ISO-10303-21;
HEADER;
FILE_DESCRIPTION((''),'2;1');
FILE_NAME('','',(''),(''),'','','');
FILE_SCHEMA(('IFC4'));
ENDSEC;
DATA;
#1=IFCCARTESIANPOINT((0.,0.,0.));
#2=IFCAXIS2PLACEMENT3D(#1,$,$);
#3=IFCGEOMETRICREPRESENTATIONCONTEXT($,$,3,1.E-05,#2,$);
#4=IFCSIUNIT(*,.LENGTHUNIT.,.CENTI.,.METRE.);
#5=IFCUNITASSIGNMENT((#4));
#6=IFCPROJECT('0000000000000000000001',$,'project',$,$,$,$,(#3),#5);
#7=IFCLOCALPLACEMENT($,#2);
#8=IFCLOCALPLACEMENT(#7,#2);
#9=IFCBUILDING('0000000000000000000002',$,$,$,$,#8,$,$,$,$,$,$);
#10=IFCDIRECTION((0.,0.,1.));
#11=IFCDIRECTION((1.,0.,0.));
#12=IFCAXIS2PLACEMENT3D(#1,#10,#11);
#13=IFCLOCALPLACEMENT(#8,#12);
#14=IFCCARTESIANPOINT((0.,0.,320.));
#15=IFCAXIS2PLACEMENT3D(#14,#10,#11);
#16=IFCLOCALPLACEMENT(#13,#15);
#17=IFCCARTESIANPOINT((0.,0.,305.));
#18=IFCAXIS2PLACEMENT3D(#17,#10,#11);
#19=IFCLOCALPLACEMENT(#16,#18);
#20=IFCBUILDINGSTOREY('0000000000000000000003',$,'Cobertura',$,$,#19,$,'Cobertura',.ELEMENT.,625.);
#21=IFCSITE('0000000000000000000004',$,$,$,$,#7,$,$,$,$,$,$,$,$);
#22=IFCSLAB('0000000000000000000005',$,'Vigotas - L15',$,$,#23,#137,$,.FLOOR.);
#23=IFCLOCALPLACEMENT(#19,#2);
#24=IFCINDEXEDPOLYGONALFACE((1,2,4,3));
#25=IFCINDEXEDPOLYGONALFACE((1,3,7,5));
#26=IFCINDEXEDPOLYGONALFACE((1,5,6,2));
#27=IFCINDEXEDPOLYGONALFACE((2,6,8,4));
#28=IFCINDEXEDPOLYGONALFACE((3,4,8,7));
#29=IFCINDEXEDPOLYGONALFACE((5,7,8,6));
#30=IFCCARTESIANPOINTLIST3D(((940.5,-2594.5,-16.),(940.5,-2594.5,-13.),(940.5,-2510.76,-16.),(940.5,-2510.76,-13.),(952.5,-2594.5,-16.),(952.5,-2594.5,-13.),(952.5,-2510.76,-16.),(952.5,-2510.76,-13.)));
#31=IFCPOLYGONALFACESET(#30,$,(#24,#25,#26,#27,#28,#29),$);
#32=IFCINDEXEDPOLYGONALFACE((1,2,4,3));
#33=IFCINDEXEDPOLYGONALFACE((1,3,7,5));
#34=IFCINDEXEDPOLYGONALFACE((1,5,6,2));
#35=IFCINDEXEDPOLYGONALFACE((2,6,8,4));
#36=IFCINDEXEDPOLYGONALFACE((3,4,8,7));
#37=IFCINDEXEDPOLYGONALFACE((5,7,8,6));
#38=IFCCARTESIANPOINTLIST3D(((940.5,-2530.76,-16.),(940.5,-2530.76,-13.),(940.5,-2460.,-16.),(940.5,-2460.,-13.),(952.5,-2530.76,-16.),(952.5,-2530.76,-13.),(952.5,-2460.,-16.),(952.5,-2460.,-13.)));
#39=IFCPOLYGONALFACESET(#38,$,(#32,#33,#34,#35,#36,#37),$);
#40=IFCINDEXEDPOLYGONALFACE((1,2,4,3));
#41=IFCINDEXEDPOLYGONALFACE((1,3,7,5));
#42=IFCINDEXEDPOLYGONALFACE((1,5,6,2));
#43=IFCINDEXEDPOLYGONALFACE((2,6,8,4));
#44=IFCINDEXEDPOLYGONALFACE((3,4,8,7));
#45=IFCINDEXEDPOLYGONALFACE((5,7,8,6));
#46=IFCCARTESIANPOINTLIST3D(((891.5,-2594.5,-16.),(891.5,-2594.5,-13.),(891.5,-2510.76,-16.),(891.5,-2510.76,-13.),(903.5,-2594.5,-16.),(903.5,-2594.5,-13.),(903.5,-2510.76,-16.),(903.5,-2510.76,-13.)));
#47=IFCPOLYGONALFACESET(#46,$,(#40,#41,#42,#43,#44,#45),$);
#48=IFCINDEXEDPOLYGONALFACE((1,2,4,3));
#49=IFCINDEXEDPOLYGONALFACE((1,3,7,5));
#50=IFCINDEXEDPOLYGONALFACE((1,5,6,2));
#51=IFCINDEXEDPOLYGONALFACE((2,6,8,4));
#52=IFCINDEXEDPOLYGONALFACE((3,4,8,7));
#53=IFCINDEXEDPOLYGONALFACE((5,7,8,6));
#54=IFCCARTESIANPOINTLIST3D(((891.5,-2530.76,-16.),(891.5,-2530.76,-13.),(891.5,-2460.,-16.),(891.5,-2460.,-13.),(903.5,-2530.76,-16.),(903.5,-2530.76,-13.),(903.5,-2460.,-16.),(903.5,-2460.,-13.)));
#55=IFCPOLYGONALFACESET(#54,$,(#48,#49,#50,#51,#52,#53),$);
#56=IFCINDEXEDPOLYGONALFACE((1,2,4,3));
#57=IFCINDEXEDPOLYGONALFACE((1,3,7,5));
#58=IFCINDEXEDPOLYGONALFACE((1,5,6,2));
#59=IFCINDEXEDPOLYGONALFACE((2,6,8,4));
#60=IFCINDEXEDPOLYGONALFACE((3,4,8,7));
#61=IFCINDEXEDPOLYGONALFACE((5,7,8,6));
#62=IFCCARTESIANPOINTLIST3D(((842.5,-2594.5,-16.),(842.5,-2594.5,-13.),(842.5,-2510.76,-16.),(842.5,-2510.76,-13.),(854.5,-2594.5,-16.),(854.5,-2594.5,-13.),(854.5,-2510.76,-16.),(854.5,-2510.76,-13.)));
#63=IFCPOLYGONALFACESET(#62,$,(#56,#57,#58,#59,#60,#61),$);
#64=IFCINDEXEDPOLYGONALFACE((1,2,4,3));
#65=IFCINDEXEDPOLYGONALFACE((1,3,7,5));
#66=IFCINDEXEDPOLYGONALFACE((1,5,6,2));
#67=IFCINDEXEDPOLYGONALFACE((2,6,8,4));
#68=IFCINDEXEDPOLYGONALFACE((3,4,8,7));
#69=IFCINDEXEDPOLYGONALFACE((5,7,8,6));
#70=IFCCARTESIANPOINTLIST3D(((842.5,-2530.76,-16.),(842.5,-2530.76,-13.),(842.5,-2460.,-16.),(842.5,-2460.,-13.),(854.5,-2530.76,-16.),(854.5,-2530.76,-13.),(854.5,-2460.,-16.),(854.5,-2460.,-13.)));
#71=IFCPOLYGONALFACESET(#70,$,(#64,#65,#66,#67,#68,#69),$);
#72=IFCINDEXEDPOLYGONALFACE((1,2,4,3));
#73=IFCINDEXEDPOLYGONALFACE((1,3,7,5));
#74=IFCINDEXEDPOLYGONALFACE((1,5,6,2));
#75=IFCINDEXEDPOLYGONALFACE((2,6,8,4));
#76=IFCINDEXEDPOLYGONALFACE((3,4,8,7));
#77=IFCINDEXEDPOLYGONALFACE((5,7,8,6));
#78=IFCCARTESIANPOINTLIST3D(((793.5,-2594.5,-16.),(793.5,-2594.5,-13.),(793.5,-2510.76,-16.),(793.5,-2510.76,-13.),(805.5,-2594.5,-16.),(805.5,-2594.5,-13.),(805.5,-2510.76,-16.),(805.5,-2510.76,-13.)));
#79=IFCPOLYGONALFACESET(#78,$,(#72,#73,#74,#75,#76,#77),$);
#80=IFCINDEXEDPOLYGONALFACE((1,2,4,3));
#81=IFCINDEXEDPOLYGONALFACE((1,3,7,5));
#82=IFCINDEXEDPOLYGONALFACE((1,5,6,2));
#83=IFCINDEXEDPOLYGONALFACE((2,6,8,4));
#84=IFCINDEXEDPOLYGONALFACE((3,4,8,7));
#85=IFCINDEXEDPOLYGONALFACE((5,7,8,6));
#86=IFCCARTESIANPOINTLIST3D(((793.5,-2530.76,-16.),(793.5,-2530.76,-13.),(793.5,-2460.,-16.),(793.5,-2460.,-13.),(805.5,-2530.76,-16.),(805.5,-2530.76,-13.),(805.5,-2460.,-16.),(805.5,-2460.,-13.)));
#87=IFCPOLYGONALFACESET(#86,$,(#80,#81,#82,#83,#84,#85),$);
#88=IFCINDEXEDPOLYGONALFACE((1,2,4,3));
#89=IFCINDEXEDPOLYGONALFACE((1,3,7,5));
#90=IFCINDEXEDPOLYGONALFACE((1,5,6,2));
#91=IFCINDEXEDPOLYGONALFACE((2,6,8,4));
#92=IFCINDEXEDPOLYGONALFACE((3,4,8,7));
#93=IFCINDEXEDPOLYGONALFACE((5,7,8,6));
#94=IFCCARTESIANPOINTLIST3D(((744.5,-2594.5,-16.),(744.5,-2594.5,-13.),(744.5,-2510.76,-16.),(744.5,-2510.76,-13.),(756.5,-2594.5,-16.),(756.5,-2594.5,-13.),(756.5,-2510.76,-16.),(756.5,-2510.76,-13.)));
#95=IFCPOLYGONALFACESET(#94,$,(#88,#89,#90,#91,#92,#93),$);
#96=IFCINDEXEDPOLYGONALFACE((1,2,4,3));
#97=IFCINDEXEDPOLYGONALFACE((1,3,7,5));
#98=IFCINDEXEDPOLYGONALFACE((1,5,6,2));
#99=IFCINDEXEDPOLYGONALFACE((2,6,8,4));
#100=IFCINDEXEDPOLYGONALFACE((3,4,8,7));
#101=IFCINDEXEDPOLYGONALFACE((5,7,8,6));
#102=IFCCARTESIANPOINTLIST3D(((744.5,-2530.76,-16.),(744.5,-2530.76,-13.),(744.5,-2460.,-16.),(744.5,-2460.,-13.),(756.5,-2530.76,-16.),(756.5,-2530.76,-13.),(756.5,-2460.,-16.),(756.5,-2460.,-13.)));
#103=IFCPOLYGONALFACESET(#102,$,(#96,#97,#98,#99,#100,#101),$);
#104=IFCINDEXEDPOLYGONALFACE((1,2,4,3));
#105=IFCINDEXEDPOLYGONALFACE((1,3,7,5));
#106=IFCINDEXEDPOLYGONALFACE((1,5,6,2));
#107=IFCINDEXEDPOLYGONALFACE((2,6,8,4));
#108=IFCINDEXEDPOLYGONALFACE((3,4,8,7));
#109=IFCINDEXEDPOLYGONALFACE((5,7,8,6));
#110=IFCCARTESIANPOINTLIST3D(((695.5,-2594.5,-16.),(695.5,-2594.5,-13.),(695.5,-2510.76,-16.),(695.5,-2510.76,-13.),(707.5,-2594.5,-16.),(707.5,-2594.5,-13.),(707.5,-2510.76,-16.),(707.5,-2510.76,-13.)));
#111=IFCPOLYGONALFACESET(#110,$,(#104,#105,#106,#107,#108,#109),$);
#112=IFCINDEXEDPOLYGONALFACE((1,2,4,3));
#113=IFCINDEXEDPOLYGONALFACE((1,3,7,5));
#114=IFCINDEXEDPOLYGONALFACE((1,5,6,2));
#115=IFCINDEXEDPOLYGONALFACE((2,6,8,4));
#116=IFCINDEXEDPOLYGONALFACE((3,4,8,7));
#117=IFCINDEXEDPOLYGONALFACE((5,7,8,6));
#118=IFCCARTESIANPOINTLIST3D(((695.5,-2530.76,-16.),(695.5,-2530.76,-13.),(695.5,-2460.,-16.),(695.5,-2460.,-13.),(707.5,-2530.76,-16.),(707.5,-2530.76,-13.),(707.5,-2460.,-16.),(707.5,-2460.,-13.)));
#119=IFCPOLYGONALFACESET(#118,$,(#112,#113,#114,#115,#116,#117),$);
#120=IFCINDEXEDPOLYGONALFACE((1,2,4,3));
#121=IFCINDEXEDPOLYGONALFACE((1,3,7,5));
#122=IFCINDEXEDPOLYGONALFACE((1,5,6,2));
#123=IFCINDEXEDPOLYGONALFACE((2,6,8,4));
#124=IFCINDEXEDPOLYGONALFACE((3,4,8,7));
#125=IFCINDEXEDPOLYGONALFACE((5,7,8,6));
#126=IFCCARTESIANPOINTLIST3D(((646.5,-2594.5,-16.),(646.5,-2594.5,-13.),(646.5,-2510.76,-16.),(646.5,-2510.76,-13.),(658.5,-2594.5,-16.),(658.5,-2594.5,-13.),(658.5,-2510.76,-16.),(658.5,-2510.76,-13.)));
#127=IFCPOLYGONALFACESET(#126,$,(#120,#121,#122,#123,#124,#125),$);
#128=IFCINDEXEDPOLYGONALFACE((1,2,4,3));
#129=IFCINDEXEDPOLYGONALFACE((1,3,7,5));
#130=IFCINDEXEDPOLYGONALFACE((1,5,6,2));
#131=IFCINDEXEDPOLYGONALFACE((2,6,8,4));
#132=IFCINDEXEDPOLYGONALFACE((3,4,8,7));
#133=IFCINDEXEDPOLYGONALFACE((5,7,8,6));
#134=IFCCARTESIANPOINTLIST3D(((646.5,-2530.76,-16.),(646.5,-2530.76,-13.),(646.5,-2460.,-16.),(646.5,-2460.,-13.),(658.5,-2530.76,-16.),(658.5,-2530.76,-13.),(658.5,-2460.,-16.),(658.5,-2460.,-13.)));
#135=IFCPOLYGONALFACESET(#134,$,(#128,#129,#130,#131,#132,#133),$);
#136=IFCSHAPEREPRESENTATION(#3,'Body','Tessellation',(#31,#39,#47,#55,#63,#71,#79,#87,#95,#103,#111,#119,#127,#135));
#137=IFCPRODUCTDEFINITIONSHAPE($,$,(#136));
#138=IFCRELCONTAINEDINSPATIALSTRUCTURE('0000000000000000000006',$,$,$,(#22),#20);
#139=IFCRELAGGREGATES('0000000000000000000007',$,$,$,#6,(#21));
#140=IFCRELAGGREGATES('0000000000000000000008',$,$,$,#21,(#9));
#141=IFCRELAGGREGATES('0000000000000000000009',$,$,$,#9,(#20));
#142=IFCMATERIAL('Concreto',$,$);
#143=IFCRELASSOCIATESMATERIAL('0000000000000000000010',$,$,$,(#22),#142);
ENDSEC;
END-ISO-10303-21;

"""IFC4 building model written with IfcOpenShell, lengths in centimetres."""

from ifc_helpers import new_model, si_unit, frame, origin, origin_with_axes, place, context, project, spatial, polyline, outline, extrude, material, element, save


model = new_model("IFC4")

# Units and contexts
context_of_model = context(None, 3, precision=1e-05, world=origin())
ifc_project = project(units=[si_unit("LENGTHUNIT", "METRE", prefix="CENTI")], contexts=[context_of_model])

# Site, building, storey
site_placement = place(None, origin())
site = spatial("IfcSite", under=ifc_project, at=site_placement)
building_placement = place(site_placement, origin())
building = spatial("IfcBuilding", under=site, at=building_placement)
placement_1 = place(building_placement, origin_with_axes())
placement_2 = place(placement_1, frame((0.0, 0.0, 320.0), z_axis=(0.0, 0.0, 1.0), x_axis=(1.0, 0.0, 0.0)))
storey_placement = place(placement_2, frame((0.0, 0.0, 305.0), z_axis=(0.0, 0.0, 1.0), x_axis=(1.0, 0.0, 0.0)))
storey = spatial("IfcBuildingStorey", under=building, at=storey_placement, Name="Cobertura", LongName="Cobertura", CompositionType="ELEMENT", Elevation=625.0)

# Shared definitions
ifc_material = material(Name="Concreto")

# Slab
slab_1_placement = place(storey_placement, frame((799.5, -2527.25, -13.0), z_axis=(0.0, 0.0, 1.0), x_axis=(1.0, 0.0, 0.0)))
element("IfcSlab", 1, at=slab_1_placement, inside=storey, material=ifc_material, Name="Vigotas - L15", PredefinedType="FLOOR", context=context_of_model, shape_type="SolidModel", body=[
    extrude(outline(polyline([(6.0, 1.5), (-6.0, 1.5), (-6.0, -1.5), (6.0, -1.5), (6.0, 1.5), (6.0, 1.5)])), frame((147.0, -67.25, -1.5), z_axis=(0.0, 1.0, 0.0), x_axis=(1.0, 0.0, 0.0)), (0.0, 0.0, 1.0), 83.74),
    extrude(outline(polyline([(6.0, 1.5), (-6.0, 1.5), (-6.0, -1.5), (6.0, -1.5), (6.0, 1.5), (6.0, 1.5)])), frame((147.0, -3.51, -1.5), z_axis=(0.0, 1.0, 0.0), x_axis=(1.0, 0.0, 0.0)), (0.0, 0.0, 1.0), 70.76),
    extrude(outline(polyline([(6.0, 1.5), (-6.0, 1.5), (-6.0, -1.5), (6.0, -1.5), (6.0, 1.5), (6.0, 1.5)])), frame((98.0, -67.25, -1.5), z_axis=(0.0, 1.0, 0.0), x_axis=(1.0, 0.0, 0.0)), (0.0, 0.0, 1.0), 83.74),
    extrude(outline(polyline([(6.0, 1.5), (-6.0, 1.5), (-6.0, -1.5), (6.0, -1.5), (6.0, 1.5), (6.0, 1.5)])), frame((98.0, -3.51, -1.5), z_axis=(0.0, 1.0, 0.0), x_axis=(1.0, 0.0, 0.0)), (0.0, 0.0, 1.0), 70.76),
    extrude(outline(polyline([(6.0, 1.5), (-6.0, 1.5), (-6.0, -1.5), (6.0, -1.5), (6.0, 1.5), (6.0, 1.5)])), frame((49.0, -67.25, -1.5), z_axis=(0.0, 1.0, 0.0), x_axis=(1.0, 0.0, 0.0)), (0.0, 0.0, 1.0), 83.74),
    extrude(outline(polyline([(6.0, 1.5), (-6.0, 1.5), (-6.0, -1.5), (6.0, -1.5), (6.0, 1.5), (6.0, 1.5)])), frame((49.0, -3.51, -1.5), z_axis=(0.0, 1.0, 0.0), x_axis=(1.0, 0.0, 0.0)), (0.0, 0.0, 1.0), 70.76),
    extrude(outline(polyline([(6.0, 1.5), (-6.0, 1.5), (-6.0, -1.5), (6.0, -1.5), (6.0, 1.5), (6.0, 1.5)])), frame((0.0, -67.25, -1.5), z_axis=(0.0, 1.0, 0.0), x_axis=(1.0, 0.0, 0.0)), (0.0, 0.0, 1.0), 83.74),
    extrude(outline(polyline([(6.0, 1.5), (-6.0, 1.5), (-6.0, -1.5), (6.0, -1.5), (6.0, 1.5), (6.0, 1.5)])), frame((0.0, -3.51, -1.5), z_axis=(0.0, 1.0, 0.0), x_axis=(1.0, 0.0, 0.0)), (0.0, 0.0, 1.0), 70.76),
    extrude(outline(polyline([(6.0, 1.5), (-6.0, 1.5), (-6.0, -1.5), (6.0, -1.5), (6.0, 1.5), (6.0, 1.5)])), frame((-49.0, -67.25, -1.5), z_axis=(0.0, 1.0, 0.0), x_axis=(1.0, 0.0, 0.0)), (0.0, 0.0, 1.0), 83.74),
    extrude(outline(polyline([(6.0, 1.5), (-6.0, 1.5), (-6.0, -1.5), (6.0, -1.5), (6.0, 1.5), (6.0, 1.5)])), frame((-49.0, -3.51, -1.5), z_axis=(0.0, 1.0, 0.0), x_axis=(1.0, 0.0, 0.0)), (0.0, 0.0, 1.0), 70.76),
    extrude(outline(polyline([(6.0, 1.5), (-6.0, 1.5), (-6.0, -1.5), (6.0, -1.5), (6.0, 1.5), (6.0, 1.5)])), frame((-98.0, -67.25, -1.5), z_axis=(0.0, 1.0, 0.0), x_axis=(1.0, 0.0, 0.0)), (0.0, 0.0, 1.0), 83.74),
    extrude(outline(polyline([(6.0, 1.5), (-6.0, 1.5), (-6.0, -1.5), (6.0, -1.5), (6.0, 1.5), (6.0, 1.5)])), frame((-98.0, -3.51, -1.5), z_axis=(0.0, 1.0, 0.0), x_axis=(1.0, 0.0, 0.0)), (0.0, 0.0, 1.0), 70.76),
    extrude(outline(polyline([(6.0, 1.5), (-6.0, 1.5), (-6.0, -1.5), (6.0, -1.5), (6.0, 1.5), (6.0, 1.5)])), frame((-147.0, -67.25, -1.5), z_axis=(0.0, 1.0, 0.0), x_axis=(1.0, 0.0, 0.0)), (0.0, 0.0, 1.0), 83.74),
    extrude(outline(polyline([(6.0, 1.5), (-6.0, 1.5), (-6.0, -1.5), (6.0, -1.5), (6.0, 1.5), (6.0, 1.5)])), frame((-147.0, -3.51, -1.5), z_axis=(0.0, 1.0, 0.0), x_axis=(1.0, 0.0, 0.0)), (0.0, 0.0, 1.0), 70.76),
])

save(model, "model.ifc")
